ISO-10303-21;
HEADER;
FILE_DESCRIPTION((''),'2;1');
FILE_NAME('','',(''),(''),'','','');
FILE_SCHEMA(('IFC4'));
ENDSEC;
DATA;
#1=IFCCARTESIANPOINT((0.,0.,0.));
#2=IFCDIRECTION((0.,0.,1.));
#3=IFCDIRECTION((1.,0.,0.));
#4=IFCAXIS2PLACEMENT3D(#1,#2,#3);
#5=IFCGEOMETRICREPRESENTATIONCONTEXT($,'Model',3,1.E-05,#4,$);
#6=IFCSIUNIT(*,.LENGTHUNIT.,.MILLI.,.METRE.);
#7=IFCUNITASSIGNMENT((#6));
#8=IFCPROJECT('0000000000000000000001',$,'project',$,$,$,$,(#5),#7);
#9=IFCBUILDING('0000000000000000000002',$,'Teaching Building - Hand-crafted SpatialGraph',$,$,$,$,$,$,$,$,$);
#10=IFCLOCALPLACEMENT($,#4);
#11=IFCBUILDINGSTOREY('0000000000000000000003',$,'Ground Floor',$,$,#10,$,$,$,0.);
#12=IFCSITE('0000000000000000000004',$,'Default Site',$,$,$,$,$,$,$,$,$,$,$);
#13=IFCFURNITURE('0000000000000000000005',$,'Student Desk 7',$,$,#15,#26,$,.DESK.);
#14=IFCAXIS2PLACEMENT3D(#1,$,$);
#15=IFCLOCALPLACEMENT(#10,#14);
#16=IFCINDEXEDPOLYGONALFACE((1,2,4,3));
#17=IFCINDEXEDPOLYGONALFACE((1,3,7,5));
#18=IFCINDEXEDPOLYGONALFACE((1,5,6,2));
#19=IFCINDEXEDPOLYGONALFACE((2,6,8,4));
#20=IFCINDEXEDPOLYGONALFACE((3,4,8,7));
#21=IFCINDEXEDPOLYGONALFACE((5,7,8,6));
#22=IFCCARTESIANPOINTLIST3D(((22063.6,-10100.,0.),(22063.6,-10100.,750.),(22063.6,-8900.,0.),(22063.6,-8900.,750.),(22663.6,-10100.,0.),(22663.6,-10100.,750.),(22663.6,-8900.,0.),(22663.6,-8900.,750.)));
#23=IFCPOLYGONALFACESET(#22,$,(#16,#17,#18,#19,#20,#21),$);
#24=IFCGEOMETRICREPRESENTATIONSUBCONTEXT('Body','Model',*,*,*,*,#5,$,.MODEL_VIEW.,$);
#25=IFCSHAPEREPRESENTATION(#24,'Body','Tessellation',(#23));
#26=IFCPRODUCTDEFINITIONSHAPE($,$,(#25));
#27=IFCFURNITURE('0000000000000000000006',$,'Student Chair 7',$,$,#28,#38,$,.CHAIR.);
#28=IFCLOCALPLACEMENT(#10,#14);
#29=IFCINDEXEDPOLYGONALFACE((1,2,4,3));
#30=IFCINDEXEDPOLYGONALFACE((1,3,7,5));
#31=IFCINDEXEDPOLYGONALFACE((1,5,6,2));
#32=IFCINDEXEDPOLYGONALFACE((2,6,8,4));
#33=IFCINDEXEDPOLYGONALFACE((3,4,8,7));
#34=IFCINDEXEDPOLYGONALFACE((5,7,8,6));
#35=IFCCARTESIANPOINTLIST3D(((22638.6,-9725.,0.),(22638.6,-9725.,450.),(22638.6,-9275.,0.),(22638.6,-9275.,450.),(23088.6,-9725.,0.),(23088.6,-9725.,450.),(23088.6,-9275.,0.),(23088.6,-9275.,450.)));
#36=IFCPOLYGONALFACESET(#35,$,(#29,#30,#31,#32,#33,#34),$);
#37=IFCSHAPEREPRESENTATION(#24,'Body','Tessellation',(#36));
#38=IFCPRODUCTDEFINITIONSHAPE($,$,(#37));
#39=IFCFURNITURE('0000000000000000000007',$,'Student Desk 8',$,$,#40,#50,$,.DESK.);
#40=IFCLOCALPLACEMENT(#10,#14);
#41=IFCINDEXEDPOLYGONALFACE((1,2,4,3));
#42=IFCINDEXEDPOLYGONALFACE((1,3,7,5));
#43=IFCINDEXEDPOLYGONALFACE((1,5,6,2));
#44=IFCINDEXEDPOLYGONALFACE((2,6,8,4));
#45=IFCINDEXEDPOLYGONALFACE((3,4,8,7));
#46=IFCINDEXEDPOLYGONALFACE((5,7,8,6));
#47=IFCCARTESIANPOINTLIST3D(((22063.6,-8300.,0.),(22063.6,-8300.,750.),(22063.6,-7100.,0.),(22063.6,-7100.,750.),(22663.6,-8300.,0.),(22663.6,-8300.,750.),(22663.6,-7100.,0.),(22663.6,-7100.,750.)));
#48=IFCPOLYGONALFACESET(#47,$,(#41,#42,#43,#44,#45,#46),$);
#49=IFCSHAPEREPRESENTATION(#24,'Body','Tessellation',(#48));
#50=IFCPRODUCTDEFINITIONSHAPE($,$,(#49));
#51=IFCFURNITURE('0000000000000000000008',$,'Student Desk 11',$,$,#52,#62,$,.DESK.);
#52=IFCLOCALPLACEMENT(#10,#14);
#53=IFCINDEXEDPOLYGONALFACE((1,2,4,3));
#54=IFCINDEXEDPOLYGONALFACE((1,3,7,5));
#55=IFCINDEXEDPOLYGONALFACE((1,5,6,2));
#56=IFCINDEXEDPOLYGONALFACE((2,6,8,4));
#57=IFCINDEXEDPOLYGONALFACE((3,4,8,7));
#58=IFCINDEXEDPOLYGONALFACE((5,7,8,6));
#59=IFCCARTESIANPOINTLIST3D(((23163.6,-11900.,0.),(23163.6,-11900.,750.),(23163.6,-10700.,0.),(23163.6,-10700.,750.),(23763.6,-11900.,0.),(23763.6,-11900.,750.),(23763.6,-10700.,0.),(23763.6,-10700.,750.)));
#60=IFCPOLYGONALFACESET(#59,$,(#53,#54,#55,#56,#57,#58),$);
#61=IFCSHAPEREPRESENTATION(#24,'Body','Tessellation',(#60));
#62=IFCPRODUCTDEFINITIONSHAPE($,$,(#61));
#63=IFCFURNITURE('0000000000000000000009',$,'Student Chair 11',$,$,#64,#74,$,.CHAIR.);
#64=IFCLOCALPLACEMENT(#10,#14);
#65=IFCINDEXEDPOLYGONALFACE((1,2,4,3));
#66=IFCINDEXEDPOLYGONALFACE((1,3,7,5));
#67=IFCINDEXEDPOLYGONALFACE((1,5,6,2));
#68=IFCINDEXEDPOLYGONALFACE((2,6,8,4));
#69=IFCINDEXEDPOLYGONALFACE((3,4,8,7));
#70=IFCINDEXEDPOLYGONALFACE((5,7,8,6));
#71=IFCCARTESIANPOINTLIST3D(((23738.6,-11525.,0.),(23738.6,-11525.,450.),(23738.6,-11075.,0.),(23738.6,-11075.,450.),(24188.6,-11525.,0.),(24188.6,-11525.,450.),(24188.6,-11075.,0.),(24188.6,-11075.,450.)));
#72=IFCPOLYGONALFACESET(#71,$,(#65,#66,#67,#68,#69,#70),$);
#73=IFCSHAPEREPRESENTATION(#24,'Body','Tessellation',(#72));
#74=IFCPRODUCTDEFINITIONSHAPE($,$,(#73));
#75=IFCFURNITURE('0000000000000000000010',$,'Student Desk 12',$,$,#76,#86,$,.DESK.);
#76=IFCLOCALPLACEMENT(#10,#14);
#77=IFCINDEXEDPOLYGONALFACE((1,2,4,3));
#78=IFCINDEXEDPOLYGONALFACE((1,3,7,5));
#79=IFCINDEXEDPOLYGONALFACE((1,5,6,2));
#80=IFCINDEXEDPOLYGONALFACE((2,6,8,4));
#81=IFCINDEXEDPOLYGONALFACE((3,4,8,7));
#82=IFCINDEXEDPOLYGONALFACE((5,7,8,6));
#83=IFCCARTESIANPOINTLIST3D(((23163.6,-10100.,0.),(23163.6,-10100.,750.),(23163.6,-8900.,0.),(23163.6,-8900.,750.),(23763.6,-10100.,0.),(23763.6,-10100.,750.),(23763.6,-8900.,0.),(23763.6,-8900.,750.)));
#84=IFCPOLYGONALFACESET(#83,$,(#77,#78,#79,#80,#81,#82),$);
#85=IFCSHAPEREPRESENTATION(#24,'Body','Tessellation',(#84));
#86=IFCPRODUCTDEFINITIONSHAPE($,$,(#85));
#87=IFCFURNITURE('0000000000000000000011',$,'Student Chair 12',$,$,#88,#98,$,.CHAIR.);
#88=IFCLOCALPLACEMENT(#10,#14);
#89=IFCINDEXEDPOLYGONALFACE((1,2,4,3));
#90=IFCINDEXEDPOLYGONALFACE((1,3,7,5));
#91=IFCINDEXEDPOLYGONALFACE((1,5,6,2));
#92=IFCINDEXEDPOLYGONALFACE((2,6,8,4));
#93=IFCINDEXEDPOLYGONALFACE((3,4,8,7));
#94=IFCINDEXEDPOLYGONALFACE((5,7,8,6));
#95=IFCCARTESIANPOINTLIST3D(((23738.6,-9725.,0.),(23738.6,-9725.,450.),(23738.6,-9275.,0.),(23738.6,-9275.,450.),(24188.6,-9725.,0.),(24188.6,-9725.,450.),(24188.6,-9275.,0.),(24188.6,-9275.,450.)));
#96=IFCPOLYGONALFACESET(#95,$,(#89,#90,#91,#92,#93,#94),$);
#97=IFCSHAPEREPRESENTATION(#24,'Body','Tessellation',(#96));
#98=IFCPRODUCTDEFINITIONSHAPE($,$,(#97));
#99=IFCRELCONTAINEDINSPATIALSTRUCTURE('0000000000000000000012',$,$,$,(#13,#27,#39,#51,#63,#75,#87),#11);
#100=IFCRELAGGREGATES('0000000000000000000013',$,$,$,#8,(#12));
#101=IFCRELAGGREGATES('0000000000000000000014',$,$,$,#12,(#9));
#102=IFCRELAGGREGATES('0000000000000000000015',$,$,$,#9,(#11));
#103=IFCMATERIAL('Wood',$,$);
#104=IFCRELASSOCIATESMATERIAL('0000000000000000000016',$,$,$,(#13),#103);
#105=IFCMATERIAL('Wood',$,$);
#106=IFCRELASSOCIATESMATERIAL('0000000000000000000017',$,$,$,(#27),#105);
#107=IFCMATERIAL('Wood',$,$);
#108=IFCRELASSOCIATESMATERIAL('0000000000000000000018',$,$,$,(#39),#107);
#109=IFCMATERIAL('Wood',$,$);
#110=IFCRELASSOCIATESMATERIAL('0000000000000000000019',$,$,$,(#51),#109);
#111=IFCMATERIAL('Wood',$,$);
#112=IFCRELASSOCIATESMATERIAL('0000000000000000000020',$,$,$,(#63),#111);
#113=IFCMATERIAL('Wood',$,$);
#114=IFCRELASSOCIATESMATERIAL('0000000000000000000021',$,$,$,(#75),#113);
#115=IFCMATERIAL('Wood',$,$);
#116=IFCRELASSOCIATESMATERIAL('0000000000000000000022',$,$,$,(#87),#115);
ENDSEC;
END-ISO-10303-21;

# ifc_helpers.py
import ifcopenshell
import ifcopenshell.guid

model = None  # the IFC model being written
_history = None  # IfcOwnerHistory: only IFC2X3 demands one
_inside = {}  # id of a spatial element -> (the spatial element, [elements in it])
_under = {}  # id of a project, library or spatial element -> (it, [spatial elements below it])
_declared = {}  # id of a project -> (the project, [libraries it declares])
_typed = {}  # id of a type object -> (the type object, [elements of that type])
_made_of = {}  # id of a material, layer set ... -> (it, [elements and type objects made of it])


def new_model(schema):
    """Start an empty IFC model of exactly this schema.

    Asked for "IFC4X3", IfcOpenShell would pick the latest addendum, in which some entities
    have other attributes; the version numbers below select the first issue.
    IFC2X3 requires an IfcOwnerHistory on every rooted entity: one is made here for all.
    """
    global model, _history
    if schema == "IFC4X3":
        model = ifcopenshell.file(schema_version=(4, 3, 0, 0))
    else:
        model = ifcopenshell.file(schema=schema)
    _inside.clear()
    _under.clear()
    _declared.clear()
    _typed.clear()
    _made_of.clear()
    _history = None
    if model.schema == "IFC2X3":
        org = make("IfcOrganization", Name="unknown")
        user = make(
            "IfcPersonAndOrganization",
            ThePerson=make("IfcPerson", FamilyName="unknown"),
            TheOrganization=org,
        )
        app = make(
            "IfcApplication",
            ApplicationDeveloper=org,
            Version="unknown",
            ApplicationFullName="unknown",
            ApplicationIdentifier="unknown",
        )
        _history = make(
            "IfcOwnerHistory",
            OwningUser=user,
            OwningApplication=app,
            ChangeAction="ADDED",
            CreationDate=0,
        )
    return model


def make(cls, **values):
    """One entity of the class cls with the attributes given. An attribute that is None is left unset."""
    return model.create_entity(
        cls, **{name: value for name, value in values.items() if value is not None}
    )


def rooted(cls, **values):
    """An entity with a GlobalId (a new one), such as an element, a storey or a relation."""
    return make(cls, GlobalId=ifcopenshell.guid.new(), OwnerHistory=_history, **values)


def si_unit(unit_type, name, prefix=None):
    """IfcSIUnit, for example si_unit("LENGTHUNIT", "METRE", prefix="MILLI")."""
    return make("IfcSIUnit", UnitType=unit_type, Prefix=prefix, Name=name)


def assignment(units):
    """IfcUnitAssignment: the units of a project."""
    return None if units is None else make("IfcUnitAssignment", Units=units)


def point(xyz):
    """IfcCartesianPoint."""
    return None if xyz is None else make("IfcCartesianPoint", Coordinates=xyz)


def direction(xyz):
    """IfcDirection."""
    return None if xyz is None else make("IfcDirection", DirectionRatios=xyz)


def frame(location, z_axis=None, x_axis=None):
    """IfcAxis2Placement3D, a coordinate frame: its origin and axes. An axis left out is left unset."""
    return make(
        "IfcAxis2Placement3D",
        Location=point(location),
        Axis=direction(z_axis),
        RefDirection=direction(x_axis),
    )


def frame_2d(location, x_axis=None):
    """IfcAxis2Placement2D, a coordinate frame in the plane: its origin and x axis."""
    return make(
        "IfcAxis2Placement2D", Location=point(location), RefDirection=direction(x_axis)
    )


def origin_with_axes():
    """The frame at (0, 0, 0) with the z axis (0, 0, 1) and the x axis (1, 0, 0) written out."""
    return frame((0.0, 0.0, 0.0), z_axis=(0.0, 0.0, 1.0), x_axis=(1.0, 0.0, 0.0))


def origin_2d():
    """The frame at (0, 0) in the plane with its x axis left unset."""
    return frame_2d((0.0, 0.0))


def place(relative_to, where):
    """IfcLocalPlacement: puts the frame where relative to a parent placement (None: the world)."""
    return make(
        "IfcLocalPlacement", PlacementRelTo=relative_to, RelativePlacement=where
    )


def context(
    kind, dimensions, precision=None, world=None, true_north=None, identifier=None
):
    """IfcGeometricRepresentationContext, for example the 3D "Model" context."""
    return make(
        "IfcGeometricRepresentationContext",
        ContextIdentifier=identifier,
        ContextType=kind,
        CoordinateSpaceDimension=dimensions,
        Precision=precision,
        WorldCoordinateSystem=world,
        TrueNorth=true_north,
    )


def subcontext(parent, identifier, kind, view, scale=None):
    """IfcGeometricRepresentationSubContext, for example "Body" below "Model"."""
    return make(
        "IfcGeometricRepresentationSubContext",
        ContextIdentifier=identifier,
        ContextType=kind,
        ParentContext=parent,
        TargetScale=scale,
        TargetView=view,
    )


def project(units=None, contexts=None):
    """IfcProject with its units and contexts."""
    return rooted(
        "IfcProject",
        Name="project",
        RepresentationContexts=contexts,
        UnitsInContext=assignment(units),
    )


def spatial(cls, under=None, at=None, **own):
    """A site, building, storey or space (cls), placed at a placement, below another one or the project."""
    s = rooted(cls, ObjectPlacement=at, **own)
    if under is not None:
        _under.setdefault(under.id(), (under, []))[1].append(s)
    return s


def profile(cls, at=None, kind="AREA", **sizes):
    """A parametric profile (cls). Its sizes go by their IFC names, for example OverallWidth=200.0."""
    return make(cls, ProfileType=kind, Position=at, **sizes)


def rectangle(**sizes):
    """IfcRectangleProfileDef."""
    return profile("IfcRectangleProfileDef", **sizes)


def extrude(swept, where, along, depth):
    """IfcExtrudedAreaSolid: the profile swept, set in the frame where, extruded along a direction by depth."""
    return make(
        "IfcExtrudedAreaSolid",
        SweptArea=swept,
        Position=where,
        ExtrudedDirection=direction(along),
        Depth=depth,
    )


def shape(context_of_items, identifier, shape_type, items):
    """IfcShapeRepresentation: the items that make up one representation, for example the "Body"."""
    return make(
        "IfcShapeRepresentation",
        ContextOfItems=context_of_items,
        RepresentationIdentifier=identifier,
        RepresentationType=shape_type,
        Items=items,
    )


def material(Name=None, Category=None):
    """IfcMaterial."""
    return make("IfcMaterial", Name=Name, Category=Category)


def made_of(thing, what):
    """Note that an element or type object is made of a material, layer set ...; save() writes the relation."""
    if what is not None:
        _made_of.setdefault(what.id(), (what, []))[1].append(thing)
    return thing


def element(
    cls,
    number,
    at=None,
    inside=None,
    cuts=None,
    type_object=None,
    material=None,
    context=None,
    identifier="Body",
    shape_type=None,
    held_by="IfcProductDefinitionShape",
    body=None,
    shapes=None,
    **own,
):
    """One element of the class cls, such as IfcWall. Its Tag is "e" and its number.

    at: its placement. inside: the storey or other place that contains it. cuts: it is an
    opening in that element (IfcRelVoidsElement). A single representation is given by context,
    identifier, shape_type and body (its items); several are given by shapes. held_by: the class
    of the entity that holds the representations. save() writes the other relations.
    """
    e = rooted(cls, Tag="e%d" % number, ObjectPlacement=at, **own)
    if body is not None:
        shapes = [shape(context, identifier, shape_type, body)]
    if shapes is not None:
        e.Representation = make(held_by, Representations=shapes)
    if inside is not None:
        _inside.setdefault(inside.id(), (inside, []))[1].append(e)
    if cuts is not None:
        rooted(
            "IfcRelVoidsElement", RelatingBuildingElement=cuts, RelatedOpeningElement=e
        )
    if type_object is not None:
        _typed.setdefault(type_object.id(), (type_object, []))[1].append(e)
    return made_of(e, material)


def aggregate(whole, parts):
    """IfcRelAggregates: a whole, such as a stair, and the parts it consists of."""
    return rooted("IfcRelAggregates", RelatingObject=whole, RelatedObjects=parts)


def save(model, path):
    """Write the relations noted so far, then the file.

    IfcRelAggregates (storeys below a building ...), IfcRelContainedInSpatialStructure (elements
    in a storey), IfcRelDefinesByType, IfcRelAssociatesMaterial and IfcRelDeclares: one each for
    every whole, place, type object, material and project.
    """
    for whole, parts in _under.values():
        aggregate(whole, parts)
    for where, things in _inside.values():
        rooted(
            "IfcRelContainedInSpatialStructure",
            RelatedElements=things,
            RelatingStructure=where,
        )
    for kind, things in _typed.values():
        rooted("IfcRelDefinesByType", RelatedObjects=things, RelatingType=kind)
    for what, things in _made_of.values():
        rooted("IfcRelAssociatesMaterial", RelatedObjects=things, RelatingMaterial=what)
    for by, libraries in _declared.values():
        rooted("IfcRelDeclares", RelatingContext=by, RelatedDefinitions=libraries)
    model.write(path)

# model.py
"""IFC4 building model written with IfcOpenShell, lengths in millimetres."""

from ifc_helpers import new_model, si_unit, frame, origin_with_axes, origin_2d, place, context, subcontext, project, spatial, rectangle, extrude, material, element, save


model = new_model("IFC4")

# Units and contexts
model_context = context("Model", 3, precision=1e-05, world=origin_with_axes())
body_context = subcontext(model_context, "Body", "Model", "MODEL_VIEW")
ifc_project = project(units=[si_unit("LENGTHUNIT", "METRE", prefix="MILLI")], contexts=[model_context])

# Site, building, storey
site = spatial("IfcSite", under=ifc_project, Name="Default Site")
building = spatial("IfcBuilding", under=site, Name="Teaching Building - Hand-crafted SpatialGraph")
storey_placement = place(None, origin_with_axes())
storey = spatial("IfcBuildingStorey", under=building, at=storey_placement, Name="Ground Floor", Elevation=0.0)

# Furniture
ifc_material_1 = material(Name="Wood")
furniture_1_placement = place(storey_placement, frame((22363.6, -9500.0, 0.0), z_axis=(0.0, 0.0, 1.0), x_axis=(0.0, 1.0, 0.0)))
element("IfcFurniture", 1, at=furniture_1_placement, inside=storey, material=ifc_material_1, Name="Student Desk 7", PredefinedType="DESK", context=body_context, shape_type="SweptSolid", body=[
    extrude(rectangle(XDim=1200.0, YDim=600.0, at=origin_2d()), origin_with_axes(), (0.0, 0.0, 1.0), 750.0),
])
ifc_material_2 = material(Name="Wood")
furniture_2_placement = place(storey_placement, frame((22863.6, -9500.0, 0.0), z_axis=(0.0, 0.0, 1.0), x_axis=(1.0, 0.0, 0.0)))
element("IfcFurniture", 2, at=furniture_2_placement, inside=storey, material=ifc_material_2, Name="Student Chair 7", PredefinedType="CHAIR", context=body_context, shape_type="SweptSolid", body=[
    extrude(rectangle(XDim=450.0, YDim=450.0, at=origin_2d()), origin_with_axes(), (0.0, 0.0, 1.0), 450.0),
])
ifc_material_3 = material(Name="Wood")
furniture_3_placement = place(storey_placement, frame((22363.6, -7700.0, 0.0), z_axis=(0.0, 0.0, 1.0), x_axis=(0.0, 1.0, 0.0)))
element("IfcFurniture", 3, at=furniture_3_placement, inside=storey, material=ifc_material_3, Name="Student Desk 8", PredefinedType="DESK", context=body_context, shape_type="SweptSolid", body=[
    extrude(rectangle(XDim=1200.0, YDim=600.0, at=origin_2d()), origin_with_axes(), (0.0, 0.0, 1.0), 750.0),
])
ifc_material_4 = material(Name="Wood")
furniture_4_placement = place(storey_placement, frame((23463.6, -11300.0, 0.0), z_axis=(0.0, 0.0, 1.0), x_axis=(0.0, 1.0, 0.0)))
element("IfcFurniture", 4, at=furniture_4_placement, inside=storey, material=ifc_material_4, Name="Student Desk 11", PredefinedType="DESK", context=body_context, shape_type="SweptSolid", body=[
    extrude(rectangle(XDim=1200.0, YDim=600.0, at=origin_2d()), origin_with_axes(), (0.0, 0.0, 1.0), 750.0),
])
ifc_material_5 = material(Name="Wood")
furniture_5_placement = place(storey_placement, frame((23963.6, -11300.0, 0.0), z_axis=(0.0, 0.0, 1.0), x_axis=(1.0, 0.0, 0.0)))
element("IfcFurniture", 5, at=furniture_5_placement, inside=storey, material=ifc_material_5, Name="Student Chair 11", PredefinedType="CHAIR", context=body_context, shape_type="SweptSolid", body=[
    extrude(rectangle(XDim=450.0, YDim=450.0, at=origin_2d()), origin_with_axes(), (0.0, 0.0, 1.0), 450.0),
])
ifc_material_6 = material(Name="Wood")
furniture_6_placement = place(storey_placement, frame((23463.6, -9500.0, 0.0), z_axis=(0.0, 0.0, 1.0), x_axis=(0.0, 1.0, 0.0)))
element("IfcFurniture", 6, at=furniture_6_placement, inside=storey, material=ifc_material_6, Name="Student Desk 12", PredefinedType="DESK", context=body_context, shape_type="SweptSolid", body=[
    extrude(rectangle(XDim=1200.0, YDim=600.0, at=origin_2d()), origin_with_axes(), (0.0, 0.0, 1.0), 750.0),
])
ifc_material_7 = material(Name="Wood")
furniture_7_placement = place(storey_placement, frame((23963.6, -9500.0, 0.0), z_axis=(0.0, 0.0, 1.0), x_axis=(1.0, 0.0, 0.0)))
element("IfcFurniture", 7, at=furniture_7_placement, inside=storey, material=ifc_material_7, Name="Student Chair 12", PredefinedType="CHAIR", context=body_context, shape_type="SweptSolid", body=[
    extrude(rectangle(XDim=450.0, YDim=450.0, at=origin_2d()), origin_with_axes(), (0.0, 0.0, 1.0), 450.0),
])

save(model, "model.ifc")
